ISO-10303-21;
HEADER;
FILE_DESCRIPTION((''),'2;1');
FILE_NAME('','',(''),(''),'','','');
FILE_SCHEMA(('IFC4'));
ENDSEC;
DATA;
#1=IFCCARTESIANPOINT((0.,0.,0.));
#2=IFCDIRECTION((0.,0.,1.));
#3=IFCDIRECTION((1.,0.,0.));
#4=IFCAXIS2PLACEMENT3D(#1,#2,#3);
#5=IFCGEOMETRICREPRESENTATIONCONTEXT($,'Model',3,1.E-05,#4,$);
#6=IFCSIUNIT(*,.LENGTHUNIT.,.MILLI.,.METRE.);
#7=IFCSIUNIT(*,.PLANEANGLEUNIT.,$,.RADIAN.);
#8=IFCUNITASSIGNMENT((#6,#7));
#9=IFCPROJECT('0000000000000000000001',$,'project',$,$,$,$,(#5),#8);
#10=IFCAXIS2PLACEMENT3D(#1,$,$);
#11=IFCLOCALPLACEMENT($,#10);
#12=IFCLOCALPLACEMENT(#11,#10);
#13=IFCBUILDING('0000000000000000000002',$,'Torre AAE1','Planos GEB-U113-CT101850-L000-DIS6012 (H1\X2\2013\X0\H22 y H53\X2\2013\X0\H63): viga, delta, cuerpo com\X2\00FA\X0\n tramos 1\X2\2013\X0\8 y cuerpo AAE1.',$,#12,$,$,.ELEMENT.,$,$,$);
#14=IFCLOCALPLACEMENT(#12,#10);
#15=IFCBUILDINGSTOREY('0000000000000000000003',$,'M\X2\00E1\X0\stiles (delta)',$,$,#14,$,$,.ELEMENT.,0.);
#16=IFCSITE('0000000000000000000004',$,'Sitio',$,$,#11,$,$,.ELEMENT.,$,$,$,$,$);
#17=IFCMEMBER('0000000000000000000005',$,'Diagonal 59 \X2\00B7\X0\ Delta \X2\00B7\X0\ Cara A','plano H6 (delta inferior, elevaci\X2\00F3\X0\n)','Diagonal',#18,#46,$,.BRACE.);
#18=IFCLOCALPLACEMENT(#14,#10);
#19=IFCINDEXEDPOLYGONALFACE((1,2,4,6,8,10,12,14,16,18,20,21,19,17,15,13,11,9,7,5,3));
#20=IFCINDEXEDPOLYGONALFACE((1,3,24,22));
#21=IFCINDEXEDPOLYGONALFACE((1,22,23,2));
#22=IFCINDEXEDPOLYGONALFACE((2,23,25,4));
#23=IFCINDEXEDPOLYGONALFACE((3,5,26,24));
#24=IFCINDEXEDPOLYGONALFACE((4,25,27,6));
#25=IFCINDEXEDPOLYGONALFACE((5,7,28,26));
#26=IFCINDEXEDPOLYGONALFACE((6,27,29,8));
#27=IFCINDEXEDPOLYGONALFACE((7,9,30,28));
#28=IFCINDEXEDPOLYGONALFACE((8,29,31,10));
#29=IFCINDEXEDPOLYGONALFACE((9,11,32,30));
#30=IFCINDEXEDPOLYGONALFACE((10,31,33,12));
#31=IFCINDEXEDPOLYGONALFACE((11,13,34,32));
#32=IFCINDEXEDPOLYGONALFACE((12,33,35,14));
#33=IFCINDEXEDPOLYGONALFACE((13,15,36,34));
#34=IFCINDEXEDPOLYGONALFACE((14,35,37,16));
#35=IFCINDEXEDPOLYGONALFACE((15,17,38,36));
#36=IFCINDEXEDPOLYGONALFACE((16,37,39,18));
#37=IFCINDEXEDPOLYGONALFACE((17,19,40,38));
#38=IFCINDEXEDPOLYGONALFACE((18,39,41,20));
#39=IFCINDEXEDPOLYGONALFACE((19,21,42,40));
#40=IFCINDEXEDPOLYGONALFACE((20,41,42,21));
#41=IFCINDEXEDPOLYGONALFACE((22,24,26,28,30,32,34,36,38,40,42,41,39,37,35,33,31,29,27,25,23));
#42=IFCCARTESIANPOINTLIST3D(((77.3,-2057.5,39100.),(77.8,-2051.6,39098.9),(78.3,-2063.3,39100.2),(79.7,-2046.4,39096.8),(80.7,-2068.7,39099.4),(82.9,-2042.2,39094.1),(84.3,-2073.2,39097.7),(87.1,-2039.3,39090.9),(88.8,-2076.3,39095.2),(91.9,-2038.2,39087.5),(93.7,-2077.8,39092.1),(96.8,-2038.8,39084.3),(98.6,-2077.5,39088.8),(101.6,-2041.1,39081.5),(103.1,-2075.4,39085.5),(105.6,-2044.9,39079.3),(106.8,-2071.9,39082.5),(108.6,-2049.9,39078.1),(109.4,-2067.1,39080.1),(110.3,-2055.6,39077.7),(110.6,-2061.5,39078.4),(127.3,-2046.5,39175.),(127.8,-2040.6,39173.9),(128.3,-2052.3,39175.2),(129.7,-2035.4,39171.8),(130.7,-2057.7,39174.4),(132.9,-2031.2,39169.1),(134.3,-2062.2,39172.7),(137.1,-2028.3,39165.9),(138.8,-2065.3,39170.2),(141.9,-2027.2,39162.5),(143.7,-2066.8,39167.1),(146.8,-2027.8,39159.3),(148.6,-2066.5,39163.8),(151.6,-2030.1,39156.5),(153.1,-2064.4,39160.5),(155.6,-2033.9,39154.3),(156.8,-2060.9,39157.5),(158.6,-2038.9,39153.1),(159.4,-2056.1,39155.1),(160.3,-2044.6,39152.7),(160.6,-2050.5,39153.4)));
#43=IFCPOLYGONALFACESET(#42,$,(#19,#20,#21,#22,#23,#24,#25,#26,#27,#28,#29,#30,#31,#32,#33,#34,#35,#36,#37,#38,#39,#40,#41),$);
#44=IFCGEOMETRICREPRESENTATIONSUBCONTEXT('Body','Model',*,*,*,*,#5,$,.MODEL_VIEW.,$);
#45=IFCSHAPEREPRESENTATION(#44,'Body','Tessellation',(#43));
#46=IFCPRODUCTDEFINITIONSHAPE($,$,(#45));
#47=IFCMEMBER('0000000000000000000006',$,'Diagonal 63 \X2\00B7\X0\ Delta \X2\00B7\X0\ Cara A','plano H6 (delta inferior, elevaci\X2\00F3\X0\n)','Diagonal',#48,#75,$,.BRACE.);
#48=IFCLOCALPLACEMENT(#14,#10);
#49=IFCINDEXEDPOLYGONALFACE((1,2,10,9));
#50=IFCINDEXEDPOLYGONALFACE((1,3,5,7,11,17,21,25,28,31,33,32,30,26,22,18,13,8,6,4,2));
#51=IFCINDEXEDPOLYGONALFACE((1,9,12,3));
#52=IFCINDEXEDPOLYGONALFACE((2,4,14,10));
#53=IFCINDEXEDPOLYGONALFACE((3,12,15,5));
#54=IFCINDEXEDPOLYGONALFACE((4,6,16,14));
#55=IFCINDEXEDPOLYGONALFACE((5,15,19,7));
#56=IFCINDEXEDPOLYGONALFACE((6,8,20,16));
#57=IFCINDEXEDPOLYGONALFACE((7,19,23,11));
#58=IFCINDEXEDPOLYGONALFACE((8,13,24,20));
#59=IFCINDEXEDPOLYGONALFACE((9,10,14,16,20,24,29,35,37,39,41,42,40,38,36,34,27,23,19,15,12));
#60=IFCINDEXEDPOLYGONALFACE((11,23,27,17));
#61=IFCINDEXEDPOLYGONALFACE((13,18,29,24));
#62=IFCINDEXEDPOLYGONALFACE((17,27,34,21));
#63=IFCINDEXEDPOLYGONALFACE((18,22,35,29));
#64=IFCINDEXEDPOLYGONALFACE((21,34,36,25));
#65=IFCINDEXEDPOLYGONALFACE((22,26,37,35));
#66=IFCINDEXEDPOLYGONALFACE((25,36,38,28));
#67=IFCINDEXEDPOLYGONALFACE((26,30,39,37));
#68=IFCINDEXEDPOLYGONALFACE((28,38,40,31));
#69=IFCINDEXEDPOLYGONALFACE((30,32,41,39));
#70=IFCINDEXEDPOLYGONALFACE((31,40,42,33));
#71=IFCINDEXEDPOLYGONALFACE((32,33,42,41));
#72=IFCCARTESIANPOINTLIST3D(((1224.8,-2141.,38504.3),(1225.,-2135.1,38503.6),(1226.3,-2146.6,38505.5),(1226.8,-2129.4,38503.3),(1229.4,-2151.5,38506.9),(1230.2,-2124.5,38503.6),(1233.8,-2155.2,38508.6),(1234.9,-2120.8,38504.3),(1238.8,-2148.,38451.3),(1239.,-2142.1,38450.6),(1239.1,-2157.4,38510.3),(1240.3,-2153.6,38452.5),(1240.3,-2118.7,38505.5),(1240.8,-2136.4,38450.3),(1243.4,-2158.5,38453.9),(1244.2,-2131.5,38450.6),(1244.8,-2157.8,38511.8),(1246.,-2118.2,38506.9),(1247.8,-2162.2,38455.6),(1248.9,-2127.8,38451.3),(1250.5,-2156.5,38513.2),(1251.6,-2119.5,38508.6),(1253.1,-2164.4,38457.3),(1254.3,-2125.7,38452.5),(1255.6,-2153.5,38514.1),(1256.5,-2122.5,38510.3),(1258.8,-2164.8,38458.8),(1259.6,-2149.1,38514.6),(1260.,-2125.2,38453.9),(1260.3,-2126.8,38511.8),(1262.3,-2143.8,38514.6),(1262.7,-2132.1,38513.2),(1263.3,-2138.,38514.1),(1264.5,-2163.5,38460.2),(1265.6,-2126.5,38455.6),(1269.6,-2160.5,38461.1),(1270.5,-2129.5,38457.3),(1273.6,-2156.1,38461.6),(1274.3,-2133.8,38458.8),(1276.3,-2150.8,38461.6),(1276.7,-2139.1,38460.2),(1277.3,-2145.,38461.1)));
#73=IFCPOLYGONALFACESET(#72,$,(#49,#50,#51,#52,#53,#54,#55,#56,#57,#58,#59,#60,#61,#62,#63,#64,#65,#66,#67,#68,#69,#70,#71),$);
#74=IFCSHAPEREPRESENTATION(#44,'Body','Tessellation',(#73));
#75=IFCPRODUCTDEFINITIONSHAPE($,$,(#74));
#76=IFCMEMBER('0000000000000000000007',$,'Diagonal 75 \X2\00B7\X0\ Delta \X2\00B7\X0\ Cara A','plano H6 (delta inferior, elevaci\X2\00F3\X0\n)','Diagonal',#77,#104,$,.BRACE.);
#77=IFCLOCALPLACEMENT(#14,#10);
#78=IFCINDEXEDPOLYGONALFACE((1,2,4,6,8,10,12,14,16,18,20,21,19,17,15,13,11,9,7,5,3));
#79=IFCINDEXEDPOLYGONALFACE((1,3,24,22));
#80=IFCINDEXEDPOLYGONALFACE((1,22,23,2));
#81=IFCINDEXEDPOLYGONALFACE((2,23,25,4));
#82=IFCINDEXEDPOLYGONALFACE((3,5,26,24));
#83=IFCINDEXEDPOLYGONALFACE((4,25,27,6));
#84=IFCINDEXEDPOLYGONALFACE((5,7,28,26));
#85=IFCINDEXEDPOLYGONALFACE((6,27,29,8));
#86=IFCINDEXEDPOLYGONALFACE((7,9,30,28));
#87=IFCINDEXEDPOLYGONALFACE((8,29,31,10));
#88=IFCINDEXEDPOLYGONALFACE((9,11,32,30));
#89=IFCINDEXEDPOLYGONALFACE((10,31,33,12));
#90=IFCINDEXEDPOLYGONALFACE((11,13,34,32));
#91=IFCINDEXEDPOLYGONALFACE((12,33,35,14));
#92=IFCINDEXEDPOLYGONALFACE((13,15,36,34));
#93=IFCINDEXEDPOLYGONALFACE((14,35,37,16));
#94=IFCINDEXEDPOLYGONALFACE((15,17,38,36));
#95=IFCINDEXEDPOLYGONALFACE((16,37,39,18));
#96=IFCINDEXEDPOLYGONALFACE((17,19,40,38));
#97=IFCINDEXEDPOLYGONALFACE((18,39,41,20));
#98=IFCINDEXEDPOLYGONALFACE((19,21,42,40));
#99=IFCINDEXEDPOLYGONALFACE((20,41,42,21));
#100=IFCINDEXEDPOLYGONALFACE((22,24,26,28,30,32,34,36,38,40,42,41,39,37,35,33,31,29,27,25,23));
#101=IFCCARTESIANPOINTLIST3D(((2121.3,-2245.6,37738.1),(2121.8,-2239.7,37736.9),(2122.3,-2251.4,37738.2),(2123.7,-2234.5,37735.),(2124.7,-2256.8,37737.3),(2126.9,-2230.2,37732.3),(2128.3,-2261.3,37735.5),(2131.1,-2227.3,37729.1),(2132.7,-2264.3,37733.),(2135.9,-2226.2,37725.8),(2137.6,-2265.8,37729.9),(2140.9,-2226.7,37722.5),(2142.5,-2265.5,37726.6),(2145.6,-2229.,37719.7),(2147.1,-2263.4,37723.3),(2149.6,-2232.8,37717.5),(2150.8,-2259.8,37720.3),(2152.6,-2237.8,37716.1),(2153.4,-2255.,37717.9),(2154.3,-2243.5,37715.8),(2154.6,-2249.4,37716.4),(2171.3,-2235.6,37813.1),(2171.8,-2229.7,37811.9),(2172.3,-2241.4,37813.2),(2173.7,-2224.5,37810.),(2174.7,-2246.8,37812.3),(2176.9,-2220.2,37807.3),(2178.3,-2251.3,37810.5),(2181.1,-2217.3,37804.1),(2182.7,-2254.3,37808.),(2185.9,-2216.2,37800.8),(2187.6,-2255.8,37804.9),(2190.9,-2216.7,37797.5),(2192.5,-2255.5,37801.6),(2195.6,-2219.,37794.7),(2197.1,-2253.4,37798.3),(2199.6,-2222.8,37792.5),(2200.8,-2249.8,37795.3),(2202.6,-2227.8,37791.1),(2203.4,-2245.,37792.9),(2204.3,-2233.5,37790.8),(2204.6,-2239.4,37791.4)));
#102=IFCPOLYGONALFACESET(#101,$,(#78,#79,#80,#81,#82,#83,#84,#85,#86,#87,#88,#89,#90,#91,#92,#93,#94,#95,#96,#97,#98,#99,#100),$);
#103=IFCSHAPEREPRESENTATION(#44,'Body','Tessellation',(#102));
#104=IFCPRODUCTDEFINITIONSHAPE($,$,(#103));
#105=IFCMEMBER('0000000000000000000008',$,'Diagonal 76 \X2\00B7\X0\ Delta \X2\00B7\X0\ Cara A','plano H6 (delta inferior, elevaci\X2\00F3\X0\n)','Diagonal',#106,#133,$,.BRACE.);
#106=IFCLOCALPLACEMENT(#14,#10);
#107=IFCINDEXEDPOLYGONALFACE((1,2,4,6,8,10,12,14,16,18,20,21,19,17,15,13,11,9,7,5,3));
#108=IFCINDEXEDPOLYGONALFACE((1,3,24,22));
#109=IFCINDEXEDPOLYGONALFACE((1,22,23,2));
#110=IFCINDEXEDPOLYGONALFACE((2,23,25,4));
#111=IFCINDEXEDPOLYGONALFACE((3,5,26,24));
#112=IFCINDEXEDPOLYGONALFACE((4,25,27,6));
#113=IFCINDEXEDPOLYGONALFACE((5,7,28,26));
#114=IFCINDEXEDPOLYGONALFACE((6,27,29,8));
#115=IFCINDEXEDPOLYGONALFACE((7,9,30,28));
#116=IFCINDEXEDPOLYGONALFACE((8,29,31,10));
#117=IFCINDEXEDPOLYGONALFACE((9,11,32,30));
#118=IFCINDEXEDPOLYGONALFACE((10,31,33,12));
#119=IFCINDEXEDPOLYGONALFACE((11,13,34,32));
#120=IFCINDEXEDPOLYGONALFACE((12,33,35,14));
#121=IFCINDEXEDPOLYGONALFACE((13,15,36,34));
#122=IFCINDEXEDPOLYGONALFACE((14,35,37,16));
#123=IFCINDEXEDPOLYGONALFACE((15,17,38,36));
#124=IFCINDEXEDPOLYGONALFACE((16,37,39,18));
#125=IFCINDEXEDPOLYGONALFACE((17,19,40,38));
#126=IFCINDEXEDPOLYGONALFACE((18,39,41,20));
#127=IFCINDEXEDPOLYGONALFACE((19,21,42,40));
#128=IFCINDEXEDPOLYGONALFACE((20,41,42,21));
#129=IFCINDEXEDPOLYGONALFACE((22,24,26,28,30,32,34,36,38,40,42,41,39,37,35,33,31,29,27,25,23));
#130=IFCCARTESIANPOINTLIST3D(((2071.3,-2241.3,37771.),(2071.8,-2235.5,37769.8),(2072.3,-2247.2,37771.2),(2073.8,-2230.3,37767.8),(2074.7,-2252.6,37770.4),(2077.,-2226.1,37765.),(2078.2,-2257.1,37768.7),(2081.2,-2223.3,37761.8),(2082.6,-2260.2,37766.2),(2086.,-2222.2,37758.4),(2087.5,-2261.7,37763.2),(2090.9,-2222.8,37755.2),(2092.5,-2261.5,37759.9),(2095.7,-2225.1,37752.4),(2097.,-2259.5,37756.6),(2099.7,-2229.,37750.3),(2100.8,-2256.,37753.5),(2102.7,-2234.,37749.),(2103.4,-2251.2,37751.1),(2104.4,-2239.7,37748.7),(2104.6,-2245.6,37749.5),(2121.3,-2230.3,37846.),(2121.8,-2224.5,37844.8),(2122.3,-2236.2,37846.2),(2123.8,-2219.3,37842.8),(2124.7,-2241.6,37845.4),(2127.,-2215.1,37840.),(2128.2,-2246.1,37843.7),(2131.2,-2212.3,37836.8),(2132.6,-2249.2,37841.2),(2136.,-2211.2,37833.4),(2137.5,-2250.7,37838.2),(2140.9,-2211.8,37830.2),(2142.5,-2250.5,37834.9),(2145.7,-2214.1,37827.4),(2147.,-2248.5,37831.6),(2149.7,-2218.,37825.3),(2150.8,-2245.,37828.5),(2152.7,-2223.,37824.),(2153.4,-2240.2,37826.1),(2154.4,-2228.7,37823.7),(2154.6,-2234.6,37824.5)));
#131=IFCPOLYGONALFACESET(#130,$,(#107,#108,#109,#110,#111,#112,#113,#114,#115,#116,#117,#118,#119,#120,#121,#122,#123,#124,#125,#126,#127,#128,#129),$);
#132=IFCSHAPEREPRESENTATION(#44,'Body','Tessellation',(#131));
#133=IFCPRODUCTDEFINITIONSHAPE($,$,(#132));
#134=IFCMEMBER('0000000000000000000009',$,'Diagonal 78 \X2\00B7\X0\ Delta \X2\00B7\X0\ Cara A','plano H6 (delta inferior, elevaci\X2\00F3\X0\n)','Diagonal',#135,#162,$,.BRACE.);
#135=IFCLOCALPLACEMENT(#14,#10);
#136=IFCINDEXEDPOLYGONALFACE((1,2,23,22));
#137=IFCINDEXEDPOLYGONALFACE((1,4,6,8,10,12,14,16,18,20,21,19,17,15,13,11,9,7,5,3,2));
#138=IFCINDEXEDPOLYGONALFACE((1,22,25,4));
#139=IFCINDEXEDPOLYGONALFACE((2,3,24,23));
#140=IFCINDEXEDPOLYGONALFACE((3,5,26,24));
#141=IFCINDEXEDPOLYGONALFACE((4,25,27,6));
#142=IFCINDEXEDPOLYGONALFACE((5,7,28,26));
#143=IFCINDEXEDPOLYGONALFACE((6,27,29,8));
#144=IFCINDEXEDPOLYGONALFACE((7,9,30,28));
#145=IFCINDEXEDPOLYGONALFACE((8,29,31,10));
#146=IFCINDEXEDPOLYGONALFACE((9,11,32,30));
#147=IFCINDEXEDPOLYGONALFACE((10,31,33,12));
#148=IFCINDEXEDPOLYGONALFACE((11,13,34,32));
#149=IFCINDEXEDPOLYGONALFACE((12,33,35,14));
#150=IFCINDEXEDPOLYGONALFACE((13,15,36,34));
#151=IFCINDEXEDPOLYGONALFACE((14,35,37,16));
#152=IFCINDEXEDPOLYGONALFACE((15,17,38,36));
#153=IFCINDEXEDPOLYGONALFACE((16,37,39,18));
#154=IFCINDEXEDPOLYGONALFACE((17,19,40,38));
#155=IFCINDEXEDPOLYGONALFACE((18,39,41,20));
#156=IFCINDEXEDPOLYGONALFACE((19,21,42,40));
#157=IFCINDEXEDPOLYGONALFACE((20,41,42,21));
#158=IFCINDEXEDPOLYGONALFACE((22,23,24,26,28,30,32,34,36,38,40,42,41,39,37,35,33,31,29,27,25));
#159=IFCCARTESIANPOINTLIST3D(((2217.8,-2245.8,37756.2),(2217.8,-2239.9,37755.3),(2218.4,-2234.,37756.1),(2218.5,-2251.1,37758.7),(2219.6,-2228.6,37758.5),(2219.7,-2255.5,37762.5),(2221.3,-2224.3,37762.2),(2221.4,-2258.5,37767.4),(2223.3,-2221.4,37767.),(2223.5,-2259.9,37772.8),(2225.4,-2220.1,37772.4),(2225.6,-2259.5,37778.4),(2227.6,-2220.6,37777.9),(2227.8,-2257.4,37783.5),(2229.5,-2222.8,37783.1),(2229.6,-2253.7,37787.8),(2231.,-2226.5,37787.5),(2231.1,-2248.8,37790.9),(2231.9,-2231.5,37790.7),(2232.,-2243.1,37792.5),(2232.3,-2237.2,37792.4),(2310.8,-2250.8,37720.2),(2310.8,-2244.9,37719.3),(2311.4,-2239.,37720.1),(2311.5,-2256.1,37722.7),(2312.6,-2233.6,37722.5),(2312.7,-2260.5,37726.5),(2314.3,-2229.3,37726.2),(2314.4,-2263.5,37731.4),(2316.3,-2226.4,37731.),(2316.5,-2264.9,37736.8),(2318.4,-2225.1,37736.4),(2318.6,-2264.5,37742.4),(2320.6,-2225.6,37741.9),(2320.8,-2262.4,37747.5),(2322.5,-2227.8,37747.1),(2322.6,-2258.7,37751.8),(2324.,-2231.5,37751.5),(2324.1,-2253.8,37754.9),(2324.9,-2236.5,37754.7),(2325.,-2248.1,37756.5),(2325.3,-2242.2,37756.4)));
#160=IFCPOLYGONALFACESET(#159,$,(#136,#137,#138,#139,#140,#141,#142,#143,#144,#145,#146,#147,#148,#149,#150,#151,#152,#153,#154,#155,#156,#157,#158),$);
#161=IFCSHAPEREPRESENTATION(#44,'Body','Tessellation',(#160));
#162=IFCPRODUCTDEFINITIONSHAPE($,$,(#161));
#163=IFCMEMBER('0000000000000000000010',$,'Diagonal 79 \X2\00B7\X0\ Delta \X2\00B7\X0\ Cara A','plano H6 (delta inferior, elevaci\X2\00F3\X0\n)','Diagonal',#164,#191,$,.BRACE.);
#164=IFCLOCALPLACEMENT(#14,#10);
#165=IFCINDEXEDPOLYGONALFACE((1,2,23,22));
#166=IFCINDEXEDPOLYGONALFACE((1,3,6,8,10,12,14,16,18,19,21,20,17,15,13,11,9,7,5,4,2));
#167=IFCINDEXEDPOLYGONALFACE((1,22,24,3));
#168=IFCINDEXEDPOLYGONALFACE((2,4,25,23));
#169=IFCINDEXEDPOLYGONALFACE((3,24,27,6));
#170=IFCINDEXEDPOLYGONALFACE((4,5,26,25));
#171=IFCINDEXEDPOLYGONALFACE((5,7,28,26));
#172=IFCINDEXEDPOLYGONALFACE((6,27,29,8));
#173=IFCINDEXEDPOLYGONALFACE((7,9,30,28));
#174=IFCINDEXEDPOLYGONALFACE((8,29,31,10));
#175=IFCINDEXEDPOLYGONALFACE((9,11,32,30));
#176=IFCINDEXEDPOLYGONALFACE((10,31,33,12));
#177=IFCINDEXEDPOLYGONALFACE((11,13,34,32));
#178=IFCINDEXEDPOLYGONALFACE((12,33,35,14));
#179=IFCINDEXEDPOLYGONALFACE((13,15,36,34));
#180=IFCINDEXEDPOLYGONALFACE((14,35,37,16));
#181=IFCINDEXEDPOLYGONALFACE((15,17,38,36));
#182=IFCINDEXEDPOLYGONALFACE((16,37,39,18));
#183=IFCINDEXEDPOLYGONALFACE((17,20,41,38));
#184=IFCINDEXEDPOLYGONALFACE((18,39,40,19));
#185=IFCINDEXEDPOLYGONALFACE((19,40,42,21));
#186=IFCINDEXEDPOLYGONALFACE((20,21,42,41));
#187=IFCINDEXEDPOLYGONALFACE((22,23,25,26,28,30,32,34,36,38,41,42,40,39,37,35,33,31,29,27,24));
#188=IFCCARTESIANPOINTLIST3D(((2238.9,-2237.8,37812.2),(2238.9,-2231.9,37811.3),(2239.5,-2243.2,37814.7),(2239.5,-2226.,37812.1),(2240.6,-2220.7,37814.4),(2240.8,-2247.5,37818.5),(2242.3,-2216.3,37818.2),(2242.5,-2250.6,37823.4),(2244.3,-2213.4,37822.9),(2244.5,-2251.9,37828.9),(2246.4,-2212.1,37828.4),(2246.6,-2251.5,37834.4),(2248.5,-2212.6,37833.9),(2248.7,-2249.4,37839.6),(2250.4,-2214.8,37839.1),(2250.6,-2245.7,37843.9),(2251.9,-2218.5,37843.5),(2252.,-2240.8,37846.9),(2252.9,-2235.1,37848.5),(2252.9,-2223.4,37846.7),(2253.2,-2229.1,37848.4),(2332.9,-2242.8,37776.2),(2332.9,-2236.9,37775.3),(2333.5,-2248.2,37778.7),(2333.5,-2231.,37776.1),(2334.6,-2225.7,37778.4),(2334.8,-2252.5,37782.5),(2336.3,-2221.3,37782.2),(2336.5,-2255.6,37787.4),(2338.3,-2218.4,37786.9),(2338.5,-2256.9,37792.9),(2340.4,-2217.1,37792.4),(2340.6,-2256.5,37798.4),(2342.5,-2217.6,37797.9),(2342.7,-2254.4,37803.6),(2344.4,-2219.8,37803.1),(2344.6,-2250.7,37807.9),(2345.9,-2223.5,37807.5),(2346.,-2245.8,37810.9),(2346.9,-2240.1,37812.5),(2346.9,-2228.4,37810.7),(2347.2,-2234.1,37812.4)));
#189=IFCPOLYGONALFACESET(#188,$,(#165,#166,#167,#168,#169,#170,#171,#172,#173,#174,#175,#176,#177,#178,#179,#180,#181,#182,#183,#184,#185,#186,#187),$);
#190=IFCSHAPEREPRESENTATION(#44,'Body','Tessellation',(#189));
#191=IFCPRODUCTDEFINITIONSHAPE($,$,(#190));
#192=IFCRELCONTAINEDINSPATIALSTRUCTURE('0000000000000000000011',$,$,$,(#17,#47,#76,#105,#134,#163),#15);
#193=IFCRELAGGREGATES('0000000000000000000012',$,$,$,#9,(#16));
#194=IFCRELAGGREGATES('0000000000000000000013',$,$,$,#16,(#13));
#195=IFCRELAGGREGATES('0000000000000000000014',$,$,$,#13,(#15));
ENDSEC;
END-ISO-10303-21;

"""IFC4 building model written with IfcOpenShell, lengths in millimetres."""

from ifc_helpers import new_model, si_unit, frame, origin, origin_with_axes, place, context, subcontext, project, spatial, circle, extrude, element, save


model = new_model("IFC4")

# Units and contexts
model_context = context("Model", 3, precision=1e-05, world=origin_with_axes())
body_context = subcontext(model_context, "Body", "Model", "MODEL_VIEW")
ifc_project = project(units=[si_unit("LENGTHUNIT", "METRE", prefix="MILLI"), si_unit("PLANEANGLEUNIT", "RADIAN")], contexts=[model_context])

# Site, building, storey
site_placement = place(None, origin())
site = spatial("IfcSite", under=ifc_project, at=site_placement, Name="Sitio", CompositionType="ELEMENT")
building_placement = place(site_placement, origin())
building = spatial("IfcBuilding", under=site, at=building_placement, Name="Torre AAE1", Description="Planos GEB-U113-CT101850-L000-DIS6012 (H1–H22 y H53–H63): viga, delta, cuerpo común tramos 1–8 y cuerpo AAE1.", CompositionType="ELEMENT")
storey_placement = place(building_placement, origin())
storey = spatial("IfcBuildingStorey", under=building, at=storey_placement, Name="Mástiles (delta)", CompositionType="ELEMENT", Elevation=0.0)

# Members
member_1_placement = place(storey_placement, frame((144.0, -2047.0, 39164.0), z_axis=(-0.550615, -0.121135, -0.825923), x_axis=(-0.107346, 0.991475, -0.073852)))
element("IfcMember", 1, at=member_1_placement, inside=storey, Name="Diagonal 59 · Delta · Cara A", Description="plano H6 (delta inferior, elevación)", ObjectType="Diagonal", PredefinedType="BRACE", context=body_context, shape_type="SweptSolid", body=[
    extrude(circle(Radius=20.0), None, (0.0, 0.0, 1.0), 90.8),
])
member_2_placement = place(storey_placement, frame((1258.0, -2145.0, 38456.0), z_axis=(-0.253334, 0.126667, 0.95905), x_axis=(-0.457378, 0.857899, -0.234124)))
element("IfcMember", 2, at=member_2_placement, inside=storey, Name="Diagonal 63 · Delta · Cara A", Description="plano H6 (delta inferior, elevación)", ObjectType="Diagonal", PredefinedType="BRACE", context=body_context, shape_type="SweptSolid", body=[
    extrude(circle(Radius=20.0), None, (0.0, 0.0, 1.0), 55.3),
])
member_3_placement = place(storey_placement, frame((2138.0, -2246.0, 37727.0), z_axis=(0.551318, 0.110264, 0.826977), x_axis=(-0.553229, 0.790273, 0.26345)))
element("IfcMember", 3, at=member_3_placement, inside=storey, Name="Diagonal 75 · Delta · Cara A", Description="plano H6 (delta inferior, elevación)", ObjectType="Diagonal", PredefinedType="BRACE", context=body_context, shape_type="SweptSolid", body=[
    extrude(circle(Radius=20.0), None, (0.0, 0.0, 1.0), 90.7),
])
member_4_placement = place(storey_placement, frame((2088.0, -2242.0, 37760.0), z_axis=(0.550615, 0.121135, 0.825923), x_axis=(-0.550707, 0.79627, 0.250352)))
element("IfcMember", 4, at=member_4_placement, inside=storey, Name="Diagonal 76 · Delta · Cara A", Description="plano H6 (delta inferior, elevación)", ObjectType="Diagonal", PredefinedType="BRACE", context=body_context, shape_type="SweptSolid", body=[
    extrude(circle(Radius=20.0), None, (0.0, 0.0, 1.0), 90.8),
])
member_5_placement = place(storey_placement, frame((2318.0, -2245.0, 37738.0), z_axis=(-0.931398, 0.050075, 0.360541), x_axis=(-0.085914, 0.932266, -0.351425)))
element("IfcMember", 5, at=member_5_placement, inside=storey, Name="Diagonal 78 · Delta · Cara A", Description="plano H6 (delta inferior, elevación)", ObjectType="Diagonal", PredefinedType="BRACE", context=body_context, shape_type="SweptSolid", body=[
    extrude(circle(Radius=20.0), None, (0.0, 0.0, 1.0), 99.8),
])
member_6_placement = place(storey_placement, frame((2340.0, -2237.0, 37794.0), z_axis=(-0.932707, 0.049612, 0.357207), x_axis=(-0.085516, 0.931817, -0.35271)))
element("IfcMember", 6, at=member_6_placement, inside=storey, Name="Diagonal 79 · Delta · Cara A", Description="plano H6 (delta inferior, elevación)", ObjectType="Diagonal", PredefinedType="BRACE", context=body_context, shape_type="SweptSolid", body=[
    extrude(circle(Radius=20.0), None, (0.0, 0.0, 1.0), 100.8),
])

save(model, "model.ifc")
